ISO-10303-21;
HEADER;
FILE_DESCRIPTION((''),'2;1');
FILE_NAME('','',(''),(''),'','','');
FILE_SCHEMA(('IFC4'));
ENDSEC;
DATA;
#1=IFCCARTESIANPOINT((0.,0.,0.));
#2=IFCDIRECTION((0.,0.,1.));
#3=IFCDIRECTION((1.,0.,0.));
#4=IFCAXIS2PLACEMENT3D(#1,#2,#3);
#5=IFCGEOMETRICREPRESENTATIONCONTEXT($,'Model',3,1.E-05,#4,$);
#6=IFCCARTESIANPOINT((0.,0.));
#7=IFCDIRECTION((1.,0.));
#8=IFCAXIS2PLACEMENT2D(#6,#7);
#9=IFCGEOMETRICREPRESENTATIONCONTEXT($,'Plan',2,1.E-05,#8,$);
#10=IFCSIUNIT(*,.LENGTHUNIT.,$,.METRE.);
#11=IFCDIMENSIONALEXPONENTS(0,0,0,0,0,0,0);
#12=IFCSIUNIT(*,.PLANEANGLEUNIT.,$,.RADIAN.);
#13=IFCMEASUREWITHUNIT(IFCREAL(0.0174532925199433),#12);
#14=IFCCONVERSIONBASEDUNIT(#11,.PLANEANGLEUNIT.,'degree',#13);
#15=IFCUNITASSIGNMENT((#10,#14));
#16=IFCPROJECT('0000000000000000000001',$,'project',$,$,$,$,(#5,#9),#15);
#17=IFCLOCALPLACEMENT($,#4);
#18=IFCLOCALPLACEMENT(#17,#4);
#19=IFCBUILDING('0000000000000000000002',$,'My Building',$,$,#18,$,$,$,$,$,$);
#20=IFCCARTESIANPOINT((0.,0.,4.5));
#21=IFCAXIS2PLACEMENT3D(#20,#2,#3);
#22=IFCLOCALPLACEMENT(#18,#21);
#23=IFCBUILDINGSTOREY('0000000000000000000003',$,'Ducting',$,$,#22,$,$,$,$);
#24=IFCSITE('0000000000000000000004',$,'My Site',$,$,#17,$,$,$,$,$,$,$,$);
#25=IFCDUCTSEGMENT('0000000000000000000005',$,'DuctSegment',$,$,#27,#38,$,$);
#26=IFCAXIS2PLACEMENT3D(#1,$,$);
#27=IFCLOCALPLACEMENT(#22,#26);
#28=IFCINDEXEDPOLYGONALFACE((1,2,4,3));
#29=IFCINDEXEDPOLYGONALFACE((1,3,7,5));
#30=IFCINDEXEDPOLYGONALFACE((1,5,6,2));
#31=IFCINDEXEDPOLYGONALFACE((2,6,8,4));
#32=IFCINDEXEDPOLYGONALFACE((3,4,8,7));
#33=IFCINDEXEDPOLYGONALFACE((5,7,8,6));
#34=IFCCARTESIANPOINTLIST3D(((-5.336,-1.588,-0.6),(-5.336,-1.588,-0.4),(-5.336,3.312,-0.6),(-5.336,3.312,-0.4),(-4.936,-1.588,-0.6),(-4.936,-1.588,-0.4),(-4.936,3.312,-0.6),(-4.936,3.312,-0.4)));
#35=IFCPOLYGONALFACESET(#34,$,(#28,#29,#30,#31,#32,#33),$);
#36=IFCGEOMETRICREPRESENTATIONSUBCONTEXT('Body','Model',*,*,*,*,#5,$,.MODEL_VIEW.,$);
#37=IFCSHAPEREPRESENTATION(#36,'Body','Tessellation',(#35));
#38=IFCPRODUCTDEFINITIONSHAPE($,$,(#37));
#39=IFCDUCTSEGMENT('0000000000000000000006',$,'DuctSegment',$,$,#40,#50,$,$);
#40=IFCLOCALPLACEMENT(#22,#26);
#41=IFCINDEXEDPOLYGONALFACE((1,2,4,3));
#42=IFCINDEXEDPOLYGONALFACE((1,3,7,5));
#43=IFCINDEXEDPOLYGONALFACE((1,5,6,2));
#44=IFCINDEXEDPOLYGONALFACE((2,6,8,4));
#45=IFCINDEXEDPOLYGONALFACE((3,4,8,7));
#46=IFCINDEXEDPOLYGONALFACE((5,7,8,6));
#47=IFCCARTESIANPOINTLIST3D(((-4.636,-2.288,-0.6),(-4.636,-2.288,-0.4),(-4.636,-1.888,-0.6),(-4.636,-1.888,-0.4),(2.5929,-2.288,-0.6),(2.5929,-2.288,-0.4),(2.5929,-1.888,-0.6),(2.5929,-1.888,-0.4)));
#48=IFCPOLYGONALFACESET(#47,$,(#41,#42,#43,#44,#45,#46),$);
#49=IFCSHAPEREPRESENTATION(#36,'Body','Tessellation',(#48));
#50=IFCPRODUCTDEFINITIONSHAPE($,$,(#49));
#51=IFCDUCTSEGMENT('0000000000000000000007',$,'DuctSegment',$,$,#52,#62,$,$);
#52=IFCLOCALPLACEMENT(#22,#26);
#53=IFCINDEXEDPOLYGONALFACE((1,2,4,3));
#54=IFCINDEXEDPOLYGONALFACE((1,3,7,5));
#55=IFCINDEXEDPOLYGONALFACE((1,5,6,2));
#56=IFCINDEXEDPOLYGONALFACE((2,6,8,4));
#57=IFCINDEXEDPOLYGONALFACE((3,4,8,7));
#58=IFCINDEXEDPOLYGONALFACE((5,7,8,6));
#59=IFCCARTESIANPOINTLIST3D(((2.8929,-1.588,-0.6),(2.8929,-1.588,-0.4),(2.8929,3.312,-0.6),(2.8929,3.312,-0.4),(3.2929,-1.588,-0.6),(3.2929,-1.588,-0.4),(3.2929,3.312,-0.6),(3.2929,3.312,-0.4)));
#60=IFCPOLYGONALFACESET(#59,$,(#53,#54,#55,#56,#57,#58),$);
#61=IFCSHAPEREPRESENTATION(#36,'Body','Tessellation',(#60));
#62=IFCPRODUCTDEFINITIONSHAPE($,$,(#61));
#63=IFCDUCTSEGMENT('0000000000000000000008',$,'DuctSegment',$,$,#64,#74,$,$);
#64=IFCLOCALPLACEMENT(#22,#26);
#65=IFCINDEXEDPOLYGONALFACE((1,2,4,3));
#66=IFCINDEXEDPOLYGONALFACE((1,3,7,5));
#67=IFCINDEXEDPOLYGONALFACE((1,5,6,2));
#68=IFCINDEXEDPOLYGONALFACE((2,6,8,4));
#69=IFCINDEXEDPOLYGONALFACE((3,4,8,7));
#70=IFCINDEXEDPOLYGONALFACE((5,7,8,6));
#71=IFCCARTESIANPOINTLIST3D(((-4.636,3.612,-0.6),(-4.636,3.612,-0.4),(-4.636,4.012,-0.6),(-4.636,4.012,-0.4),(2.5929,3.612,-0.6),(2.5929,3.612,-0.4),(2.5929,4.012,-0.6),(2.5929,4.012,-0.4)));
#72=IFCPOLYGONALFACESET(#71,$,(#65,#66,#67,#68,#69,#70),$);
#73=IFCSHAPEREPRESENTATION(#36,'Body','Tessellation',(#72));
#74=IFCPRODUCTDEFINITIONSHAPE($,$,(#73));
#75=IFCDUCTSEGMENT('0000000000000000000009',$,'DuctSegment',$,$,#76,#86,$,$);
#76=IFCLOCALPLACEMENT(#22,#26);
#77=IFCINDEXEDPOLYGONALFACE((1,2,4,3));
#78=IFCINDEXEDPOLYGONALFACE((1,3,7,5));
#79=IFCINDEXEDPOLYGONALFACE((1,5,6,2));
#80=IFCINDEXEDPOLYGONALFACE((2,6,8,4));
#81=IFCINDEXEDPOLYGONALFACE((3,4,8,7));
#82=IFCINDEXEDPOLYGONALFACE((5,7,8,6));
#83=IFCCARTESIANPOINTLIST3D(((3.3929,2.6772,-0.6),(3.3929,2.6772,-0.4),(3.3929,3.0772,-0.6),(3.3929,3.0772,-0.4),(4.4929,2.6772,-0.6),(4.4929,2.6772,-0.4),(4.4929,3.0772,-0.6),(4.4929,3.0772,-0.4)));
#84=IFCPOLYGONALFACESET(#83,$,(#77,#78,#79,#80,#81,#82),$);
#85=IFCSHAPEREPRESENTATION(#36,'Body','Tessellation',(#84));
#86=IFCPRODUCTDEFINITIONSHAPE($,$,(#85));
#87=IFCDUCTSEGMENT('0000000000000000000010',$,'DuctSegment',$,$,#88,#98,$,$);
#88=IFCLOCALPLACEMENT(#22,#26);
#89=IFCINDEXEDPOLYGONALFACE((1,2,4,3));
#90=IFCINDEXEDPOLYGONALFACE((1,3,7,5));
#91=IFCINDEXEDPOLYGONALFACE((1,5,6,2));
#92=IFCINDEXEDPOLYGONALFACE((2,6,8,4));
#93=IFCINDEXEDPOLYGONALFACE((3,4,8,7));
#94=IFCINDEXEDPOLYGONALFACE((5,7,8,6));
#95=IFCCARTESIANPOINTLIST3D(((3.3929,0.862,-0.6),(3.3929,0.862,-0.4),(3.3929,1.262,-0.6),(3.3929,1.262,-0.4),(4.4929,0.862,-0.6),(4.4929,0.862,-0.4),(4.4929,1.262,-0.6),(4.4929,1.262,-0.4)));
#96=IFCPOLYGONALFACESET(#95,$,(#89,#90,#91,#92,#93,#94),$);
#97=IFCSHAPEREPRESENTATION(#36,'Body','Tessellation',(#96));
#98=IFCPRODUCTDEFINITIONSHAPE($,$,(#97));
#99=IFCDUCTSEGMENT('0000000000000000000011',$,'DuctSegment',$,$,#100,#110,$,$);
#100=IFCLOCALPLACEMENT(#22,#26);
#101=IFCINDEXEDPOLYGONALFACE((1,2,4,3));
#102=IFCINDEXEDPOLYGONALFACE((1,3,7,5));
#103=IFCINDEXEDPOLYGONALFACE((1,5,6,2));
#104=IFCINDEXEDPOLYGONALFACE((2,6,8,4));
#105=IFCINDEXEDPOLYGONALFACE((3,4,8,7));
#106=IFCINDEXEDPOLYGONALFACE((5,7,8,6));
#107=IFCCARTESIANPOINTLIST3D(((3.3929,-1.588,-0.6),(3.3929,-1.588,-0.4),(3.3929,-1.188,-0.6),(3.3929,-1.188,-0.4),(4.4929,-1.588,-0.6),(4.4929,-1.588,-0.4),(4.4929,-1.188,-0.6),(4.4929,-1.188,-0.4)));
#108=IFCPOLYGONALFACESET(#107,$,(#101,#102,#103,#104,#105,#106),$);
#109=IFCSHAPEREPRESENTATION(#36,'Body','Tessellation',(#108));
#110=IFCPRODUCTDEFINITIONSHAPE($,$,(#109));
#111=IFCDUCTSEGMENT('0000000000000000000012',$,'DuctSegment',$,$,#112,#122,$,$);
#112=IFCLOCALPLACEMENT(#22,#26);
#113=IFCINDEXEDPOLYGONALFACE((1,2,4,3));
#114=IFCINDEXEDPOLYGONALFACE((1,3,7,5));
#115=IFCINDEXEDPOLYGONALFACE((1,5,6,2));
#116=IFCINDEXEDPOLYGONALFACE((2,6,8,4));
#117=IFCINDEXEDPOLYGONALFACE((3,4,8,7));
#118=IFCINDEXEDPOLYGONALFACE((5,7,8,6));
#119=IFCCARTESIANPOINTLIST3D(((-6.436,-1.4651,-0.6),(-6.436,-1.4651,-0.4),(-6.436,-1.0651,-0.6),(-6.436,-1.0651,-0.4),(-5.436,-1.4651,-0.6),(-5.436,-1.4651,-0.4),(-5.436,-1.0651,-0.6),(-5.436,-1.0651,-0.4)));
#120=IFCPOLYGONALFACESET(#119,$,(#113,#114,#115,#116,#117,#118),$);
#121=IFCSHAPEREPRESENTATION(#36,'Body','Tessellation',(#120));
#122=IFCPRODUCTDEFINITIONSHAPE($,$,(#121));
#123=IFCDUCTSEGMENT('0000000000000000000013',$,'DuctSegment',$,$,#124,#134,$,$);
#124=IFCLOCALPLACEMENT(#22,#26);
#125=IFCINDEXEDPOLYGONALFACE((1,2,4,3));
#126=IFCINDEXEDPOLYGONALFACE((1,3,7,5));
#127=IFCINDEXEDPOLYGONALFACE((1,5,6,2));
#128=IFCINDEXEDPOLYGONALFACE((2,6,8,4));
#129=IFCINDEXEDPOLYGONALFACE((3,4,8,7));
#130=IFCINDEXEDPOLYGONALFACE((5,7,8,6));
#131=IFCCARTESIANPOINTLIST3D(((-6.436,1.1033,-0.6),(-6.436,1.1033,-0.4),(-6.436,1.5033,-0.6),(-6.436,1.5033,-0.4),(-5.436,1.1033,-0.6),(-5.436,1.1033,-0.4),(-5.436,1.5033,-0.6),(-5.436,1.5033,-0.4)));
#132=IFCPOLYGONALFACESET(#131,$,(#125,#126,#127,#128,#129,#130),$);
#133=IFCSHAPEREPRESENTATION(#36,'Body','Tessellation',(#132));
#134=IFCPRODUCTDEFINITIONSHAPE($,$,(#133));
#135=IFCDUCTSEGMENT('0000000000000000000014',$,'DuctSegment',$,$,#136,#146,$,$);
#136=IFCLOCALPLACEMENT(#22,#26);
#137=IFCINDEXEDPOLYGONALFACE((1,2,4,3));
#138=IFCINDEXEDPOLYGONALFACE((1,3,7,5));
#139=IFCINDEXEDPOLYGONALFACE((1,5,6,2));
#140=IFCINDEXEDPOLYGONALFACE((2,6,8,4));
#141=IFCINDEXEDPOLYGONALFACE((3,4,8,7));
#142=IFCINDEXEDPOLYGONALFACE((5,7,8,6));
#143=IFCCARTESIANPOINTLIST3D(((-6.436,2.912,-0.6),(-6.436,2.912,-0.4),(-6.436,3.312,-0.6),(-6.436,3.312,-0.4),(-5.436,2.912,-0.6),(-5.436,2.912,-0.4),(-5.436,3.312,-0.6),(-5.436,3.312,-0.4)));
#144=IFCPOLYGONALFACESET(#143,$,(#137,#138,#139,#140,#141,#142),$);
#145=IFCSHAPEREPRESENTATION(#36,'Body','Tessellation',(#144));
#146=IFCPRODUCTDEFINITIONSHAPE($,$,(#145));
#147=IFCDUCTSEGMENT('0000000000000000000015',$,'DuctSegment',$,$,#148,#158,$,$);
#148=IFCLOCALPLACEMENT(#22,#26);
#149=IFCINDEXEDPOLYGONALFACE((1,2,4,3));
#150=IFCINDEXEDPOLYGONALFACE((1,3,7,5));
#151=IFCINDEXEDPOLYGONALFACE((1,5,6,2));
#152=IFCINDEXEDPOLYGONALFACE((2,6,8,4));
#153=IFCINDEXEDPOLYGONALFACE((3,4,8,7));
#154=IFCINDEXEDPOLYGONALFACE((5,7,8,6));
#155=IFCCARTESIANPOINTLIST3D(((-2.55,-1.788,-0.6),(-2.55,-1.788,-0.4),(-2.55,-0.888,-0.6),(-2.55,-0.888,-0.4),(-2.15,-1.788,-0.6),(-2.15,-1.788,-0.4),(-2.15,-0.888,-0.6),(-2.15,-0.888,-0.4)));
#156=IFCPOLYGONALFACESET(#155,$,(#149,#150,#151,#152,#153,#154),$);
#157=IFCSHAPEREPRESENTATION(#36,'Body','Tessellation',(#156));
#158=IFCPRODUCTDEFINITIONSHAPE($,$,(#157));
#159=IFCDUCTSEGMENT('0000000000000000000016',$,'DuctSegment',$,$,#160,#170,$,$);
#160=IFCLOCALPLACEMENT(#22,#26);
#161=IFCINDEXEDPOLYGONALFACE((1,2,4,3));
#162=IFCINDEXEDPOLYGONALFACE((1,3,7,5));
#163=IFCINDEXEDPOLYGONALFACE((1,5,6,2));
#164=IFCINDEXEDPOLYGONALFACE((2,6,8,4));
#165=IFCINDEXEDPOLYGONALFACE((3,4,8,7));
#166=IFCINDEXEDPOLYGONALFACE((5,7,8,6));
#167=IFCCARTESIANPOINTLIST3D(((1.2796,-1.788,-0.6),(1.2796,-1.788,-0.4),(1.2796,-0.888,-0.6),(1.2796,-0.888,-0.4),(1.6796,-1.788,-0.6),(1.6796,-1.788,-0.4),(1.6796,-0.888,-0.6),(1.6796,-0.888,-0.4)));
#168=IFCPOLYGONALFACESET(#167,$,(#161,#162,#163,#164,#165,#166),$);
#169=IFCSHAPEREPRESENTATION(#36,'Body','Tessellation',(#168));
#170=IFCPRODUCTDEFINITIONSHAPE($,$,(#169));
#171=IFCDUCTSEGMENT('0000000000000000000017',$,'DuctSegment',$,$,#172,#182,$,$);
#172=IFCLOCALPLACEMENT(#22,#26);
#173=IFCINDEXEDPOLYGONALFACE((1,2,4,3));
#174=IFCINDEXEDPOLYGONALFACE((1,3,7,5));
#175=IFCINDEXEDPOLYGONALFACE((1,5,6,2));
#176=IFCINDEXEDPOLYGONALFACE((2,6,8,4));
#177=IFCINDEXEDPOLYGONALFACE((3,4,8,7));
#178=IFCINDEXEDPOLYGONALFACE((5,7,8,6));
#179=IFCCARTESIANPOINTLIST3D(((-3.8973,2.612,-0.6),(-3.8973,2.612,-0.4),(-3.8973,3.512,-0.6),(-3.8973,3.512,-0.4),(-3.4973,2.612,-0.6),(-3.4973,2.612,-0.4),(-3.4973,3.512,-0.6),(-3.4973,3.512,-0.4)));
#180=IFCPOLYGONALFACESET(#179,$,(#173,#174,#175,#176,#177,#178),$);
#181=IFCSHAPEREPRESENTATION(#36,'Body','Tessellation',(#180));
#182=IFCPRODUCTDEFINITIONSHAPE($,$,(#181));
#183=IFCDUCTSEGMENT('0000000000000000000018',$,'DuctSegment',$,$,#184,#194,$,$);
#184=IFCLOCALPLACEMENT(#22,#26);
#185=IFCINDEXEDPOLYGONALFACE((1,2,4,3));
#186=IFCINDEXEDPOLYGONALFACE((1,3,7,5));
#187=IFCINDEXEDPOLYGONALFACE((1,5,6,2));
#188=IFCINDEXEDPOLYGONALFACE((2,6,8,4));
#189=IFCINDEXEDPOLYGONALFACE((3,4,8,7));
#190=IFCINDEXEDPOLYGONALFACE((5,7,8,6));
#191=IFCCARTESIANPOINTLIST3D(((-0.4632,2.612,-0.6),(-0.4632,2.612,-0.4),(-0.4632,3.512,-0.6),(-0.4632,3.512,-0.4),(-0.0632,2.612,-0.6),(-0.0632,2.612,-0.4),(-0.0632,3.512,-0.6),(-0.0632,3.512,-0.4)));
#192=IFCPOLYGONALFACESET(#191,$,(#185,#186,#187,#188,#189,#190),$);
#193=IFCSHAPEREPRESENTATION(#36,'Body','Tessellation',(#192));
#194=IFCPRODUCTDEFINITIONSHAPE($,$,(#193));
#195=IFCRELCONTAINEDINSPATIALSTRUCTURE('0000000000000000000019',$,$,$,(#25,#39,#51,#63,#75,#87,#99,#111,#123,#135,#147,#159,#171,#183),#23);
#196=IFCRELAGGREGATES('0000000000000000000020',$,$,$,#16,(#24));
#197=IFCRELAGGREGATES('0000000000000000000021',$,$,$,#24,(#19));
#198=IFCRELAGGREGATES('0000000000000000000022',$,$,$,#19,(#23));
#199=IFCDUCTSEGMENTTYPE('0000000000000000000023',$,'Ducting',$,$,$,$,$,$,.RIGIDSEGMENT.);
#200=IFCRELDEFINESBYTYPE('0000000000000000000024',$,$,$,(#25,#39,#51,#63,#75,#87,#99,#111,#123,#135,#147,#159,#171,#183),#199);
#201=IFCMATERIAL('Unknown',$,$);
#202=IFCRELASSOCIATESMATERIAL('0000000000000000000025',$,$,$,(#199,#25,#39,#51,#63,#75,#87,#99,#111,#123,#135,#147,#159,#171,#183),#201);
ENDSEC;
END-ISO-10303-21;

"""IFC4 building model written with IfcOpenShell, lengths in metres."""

from ifc_helpers import new_model, entity, si_unit, converted_unit, frame, origin_with_axes, origin_2d_with_axis, place, context, subcontext, project, spatial, rectangle, extrude, material, material_profile, profile_set, profile_usage, type_object, element, save


model = new_model("IFC4")

# Units and contexts
model_context = context("Model", 3, precision=1e-05, world=origin_with_axes())
plan_context = context("Plan", 2, precision=1e-05, world=origin_2d_with_axis())
body_context = subcontext(model_context, "Body", "Model", "MODEL_VIEW")
ifc_project = project(units=[si_unit("LENGTHUNIT", "METRE"), converted_unit("PLANEANGLEUNIT", "degree", entity("IfcReal", 0.0174532925199433), si_unit("PLANEANGLEUNIT", "RADIAN"), dimensions=[0, 0, 0, 0, 0, 0, 0])], contexts=[model_context, plan_context])

# Site, building, storey
site_placement = place(None, origin_with_axes())
site = spatial("IfcSite", under=ifc_project, at=site_placement, Name="My Site")
building_placement = place(site_placement, origin_with_axes())
building = spatial("IfcBuilding", under=site, at=building_placement, Name="My Building")
storey_placement = place(building_placement, frame((0.0, 0.0, 4.5), z_axis=(0.0, 0.0, 1.0), x_axis=(1.0, 0.0, 0.0)))
storey = spatial("IfcBuildingStorey", under=building, at=storey_placement, Name="Ducting")

# Duct segments
ifc_material = material(Name="Unknown")
ifc_material_profile_1 = material_profile(ifc_material, rectangle(XDim=0.4, YDim=0.2))
ifc_profile_set_1 = profile_set([ifc_material_profile_1])
ifc_profile_usage_1 = profile_usage(ifc_profile_set_1, cardinal=5)
duct_segment_type = type_object("IfcDuctSegmentType", Name="Ducting", PredefinedType="RIGIDSEGMENT", material=ifc_profile_set_1)
duct_segment_1_placement = place(storey_placement, frame((-5.136, -1.588, -0.5), z_axis=(0.0, 1.0, 0.0), x_axis=(-1.0, 0.0, 0.0)))
element("IfcDuctSegment", 1, at=duct_segment_1_placement, inside=storey, type_object=duct_segment_type, material=ifc_profile_usage_1, Name="DuctSegment", context=body_context, shape_type="SweptSolid", body=[
    extrude(rectangle(XDim=0.4, YDim=0.2), origin_with_axes(), (0.0, 0.0, 1.0), 4.9),
])
ifc_profile_usage_2 = profile_usage(ifc_profile_set_1, cardinal=5)
duct_segment_2_placement = place(storey_placement, frame((-4.636, -2.088, -0.5), z_axis=(1.0, -0.000001, 0.000001), x_axis=(0.000001, 1.0, 0.0)))
element("IfcDuctSegment", 2, at=duct_segment_2_placement, inside=storey, type_object=duct_segment_type, material=ifc_profile_usage_2, Name="DuctSegment", context=body_context, shape_type="SweptSolid", body=[
    extrude(rectangle(XDim=0.4, YDim=0.2), origin_with_axes(), (0.0, 0.0, 1.0), 7.2289),
])
ifc_profile_usage_3 = profile_usage(ifc_profile_set_1, cardinal=5)
duct_segment_3_placement = place(storey_placement, frame((3.0929, -1.588, -0.5), z_axis=(0.0, 1.0, 0.0), x_axis=(-1.0, 0.0, 0.0)))
element("IfcDuctSegment", 3, at=duct_segment_3_placement, inside=storey, type_object=duct_segment_type, material=ifc_profile_usage_3, Name="DuctSegment", context=body_context, shape_type="SweptSolid", body=[
    extrude(rectangle(XDim=0.4, YDim=0.2), origin_with_axes(), (0.0, 0.0, 1.0), 4.9),
])
ifc_profile_usage_4 = profile_usage(ifc_profile_set_1, cardinal=5)
duct_segment_4_placement = place(storey_placement, frame((-4.636, 3.812, -0.5), z_axis=(1.0, -0.000001, 0.000001), x_axis=(0.000001, 1.0, 0.0)))
element("IfcDuctSegment", 4, at=duct_segment_4_placement, inside=storey, type_object=duct_segment_type, material=ifc_profile_usage_4, Name="DuctSegment", context=body_context, shape_type="SweptSolid", body=[
    extrude(rectangle(XDim=0.4, YDim=0.2), origin_with_axes(), (0.0, 0.0, 1.0), 7.2289),
])
ifc_profile_usage_5 = profile_usage(ifc_profile_set_1, cardinal=5)
duct_segment_5_placement = place(storey_placement, frame((3.3929, 2.8772, -0.5), z_axis=(1.0, 0.0, 0.0), x_axis=(0.0, 1.0, 0.0)))
element("IfcDuctSegment", 5, at=duct_segment_5_placement, inside=storey, type_object=duct_segment_type, material=ifc_profile_usage_5, Name="DuctSegment", context=body_context, shape_type="SweptSolid", body=[
    extrude(rectangle(XDim=0.4, YDim=0.2), origin_with_axes(), (0.0, 0.0, 1.0), 1.1),
])
ifc_profile_usage_6 = profile_usage(ifc_profile_set_1, cardinal=5)
duct_segment_6_placement = place(storey_placement, frame((3.3929, 1.062, -0.5), z_axis=(1.0, 0.0, 0.0), x_axis=(0.0, 1.0, 0.0)))
element("IfcDuctSegment", 6, at=duct_segment_6_placement, inside=storey, type_object=duct_segment_type, material=ifc_profile_usage_6, Name="DuctSegment", context=body_context, shape_type="SweptSolid", body=[
    extrude(rectangle(XDim=0.4, YDim=0.2), origin_with_axes(), (0.0, 0.0, 1.0), 1.1),
])
ifc_profile_usage_7 = profile_usage(ifc_profile_set_1, cardinal=5)
duct_segment_7_placement = place(storey_placement, frame((3.3929, -1.388, -0.5), z_axis=(1.0, 0.0, 0.0), x_axis=(0.0, 1.0, 0.0)))
element("IfcDuctSegment", 7, at=duct_segment_7_placement, inside=storey, type_object=duct_segment_type, material=ifc_profile_usage_7, Name="DuctSegment", context=body_context, shape_type="SweptSolid", body=[
    extrude(rectangle(XDim=0.4, YDim=0.2), origin_with_axes(), (0.0, 0.0, 1.0), 1.1),
])
ifc_profile_usage_8 = profile_usage(ifc_profile_set_1, cardinal=5)
duct_segment_8_placement = place(storey_placement, frame((-5.436, -1.2651, -0.5), z_axis=(-1.0, 0.0, 0.0), x_axis=(0.0, -1.0, 0.0)))
element("IfcDuctSegment", 8, at=duct_segment_8_placement, inside=storey, type_object=duct_segment_type, material=ifc_profile_usage_8, Name="DuctSegment", context=body_context, shape_type="SweptSolid", body=[
    extrude(rectangle(XDim=0.4, YDim=0.2), origin_with_axes(), (0.0, 0.0, 1.0), 1.0),
])
ifc_profile_usage_9 = profile_usage(ifc_profile_set_1, cardinal=5)
duct_segment_9_placement = place(storey_placement, frame((-5.436, 1.3033, -0.5), z_axis=(-1.0, 0.0, 0.0), x_axis=(0.0, -1.0, 0.0)))
element("IfcDuctSegment", 9, at=duct_segment_9_placement, inside=storey, type_object=duct_segment_type, material=ifc_profile_usage_9, Name="DuctSegment", context=body_context, shape_type="SweptSolid", body=[
    extrude(rectangle(XDim=0.4, YDim=0.2), origin_with_axes(), (0.0, 0.0, 1.0), 1.0),
])
ifc_profile_usage_10 = profile_usage(ifc_profile_set_1, cardinal=5)
duct_segment_10_placement = place(storey_placement, frame((-5.436, 3.112, -0.5), z_axis=(-1.0, 0.0, 0.0), x_axis=(0.0, -1.0, 0.0)))
element("IfcDuctSegment", 10, at=duct_segment_10_placement, inside=storey, type_object=duct_segment_type, material=ifc_profile_usage_10, Name="DuctSegment", context=body_context, shape_type="SweptSolid", body=[
    extrude(rectangle(XDim=0.4, YDim=0.2), origin_with_axes(), (0.0, 0.0, 1.0), 1.0),
])
ifc_profile_usage_11 = profile_usage(ifc_profile_set_1, cardinal=5)
duct_segment_11_placement = place(storey_placement, frame((-2.35, -0.888, -0.5), z_axis=(0.0, -1.0, 0.000004), x_axis=(1.0, 0.0, 0.0)))
element("IfcDuctSegment", 11, at=duct_segment_11_placement, inside=storey, type_object=duct_segment_type, material=ifc_profile_usage_11, Name="DuctSegment", context=body_context, shape_type="SweptSolid", body=[
    extrude(rectangle(XDim=0.4, YDim=0.2), origin_with_axes(), (0.0, 0.0, 1.0), 0.9),
])
ifc_profile_usage_12 = profile_usage(ifc_profile_set_1, cardinal=5)
duct_segment_12_placement = place(storey_placement, frame((1.4796, -0.888, -0.5), z_axis=(0.0, -1.0, 0.000004), x_axis=(1.0, 0.0, 0.0)))
element("IfcDuctSegment", 12, at=duct_segment_12_placement, inside=storey, type_object=duct_segment_type, material=ifc_profile_usage_12, Name="DuctSegment", context=body_context, shape_type="SweptSolid", body=[
    extrude(rectangle(XDim=0.4, YDim=0.2), origin_with_axes(), (0.0, 0.0, 1.0), 0.9),
])
ifc_profile_usage_13 = profile_usage(ifc_profile_set_1, cardinal=5)
duct_segment_13_placement = place(storey_placement, frame((-3.6973, 2.612, -0.5), z_axis=(0.0, 1.0, 0.000013), x_axis=(-1.0, 0.0, 0.0)))
element("IfcDuctSegment", 13, at=duct_segment_13_placement, inside=storey, type_object=duct_segment_type, material=ifc_profile_usage_13, Name="DuctSegment", context=body_context, shape_type="SweptSolid", body=[
    extrude(rectangle(XDim=0.4, YDim=0.2), origin_with_axes(), (0.0, 0.0, 1.0), 0.9),
])
ifc_profile_usage_14 = profile_usage(ifc_profile_set_1, cardinal=5)
duct_segment_14_placement = place(storey_placement, frame((-0.2632, 2.612, -0.5), z_axis=(0.0, 1.0, 0.000013), x_axis=(-1.0, 0.0, 0.0)))
element("IfcDuctSegment", 14, at=duct_segment_14_placement, inside=storey, type_object=duct_segment_type, material=ifc_profile_usage_14, Name="DuctSegment", context=body_context, shape_type="SweptSolid", body=[
    extrude(rectangle(XDim=0.4, YDim=0.2), origin_with_axes(), (0.0, 0.0, 1.0), 0.9),
])

save(model, "model.ifc")
